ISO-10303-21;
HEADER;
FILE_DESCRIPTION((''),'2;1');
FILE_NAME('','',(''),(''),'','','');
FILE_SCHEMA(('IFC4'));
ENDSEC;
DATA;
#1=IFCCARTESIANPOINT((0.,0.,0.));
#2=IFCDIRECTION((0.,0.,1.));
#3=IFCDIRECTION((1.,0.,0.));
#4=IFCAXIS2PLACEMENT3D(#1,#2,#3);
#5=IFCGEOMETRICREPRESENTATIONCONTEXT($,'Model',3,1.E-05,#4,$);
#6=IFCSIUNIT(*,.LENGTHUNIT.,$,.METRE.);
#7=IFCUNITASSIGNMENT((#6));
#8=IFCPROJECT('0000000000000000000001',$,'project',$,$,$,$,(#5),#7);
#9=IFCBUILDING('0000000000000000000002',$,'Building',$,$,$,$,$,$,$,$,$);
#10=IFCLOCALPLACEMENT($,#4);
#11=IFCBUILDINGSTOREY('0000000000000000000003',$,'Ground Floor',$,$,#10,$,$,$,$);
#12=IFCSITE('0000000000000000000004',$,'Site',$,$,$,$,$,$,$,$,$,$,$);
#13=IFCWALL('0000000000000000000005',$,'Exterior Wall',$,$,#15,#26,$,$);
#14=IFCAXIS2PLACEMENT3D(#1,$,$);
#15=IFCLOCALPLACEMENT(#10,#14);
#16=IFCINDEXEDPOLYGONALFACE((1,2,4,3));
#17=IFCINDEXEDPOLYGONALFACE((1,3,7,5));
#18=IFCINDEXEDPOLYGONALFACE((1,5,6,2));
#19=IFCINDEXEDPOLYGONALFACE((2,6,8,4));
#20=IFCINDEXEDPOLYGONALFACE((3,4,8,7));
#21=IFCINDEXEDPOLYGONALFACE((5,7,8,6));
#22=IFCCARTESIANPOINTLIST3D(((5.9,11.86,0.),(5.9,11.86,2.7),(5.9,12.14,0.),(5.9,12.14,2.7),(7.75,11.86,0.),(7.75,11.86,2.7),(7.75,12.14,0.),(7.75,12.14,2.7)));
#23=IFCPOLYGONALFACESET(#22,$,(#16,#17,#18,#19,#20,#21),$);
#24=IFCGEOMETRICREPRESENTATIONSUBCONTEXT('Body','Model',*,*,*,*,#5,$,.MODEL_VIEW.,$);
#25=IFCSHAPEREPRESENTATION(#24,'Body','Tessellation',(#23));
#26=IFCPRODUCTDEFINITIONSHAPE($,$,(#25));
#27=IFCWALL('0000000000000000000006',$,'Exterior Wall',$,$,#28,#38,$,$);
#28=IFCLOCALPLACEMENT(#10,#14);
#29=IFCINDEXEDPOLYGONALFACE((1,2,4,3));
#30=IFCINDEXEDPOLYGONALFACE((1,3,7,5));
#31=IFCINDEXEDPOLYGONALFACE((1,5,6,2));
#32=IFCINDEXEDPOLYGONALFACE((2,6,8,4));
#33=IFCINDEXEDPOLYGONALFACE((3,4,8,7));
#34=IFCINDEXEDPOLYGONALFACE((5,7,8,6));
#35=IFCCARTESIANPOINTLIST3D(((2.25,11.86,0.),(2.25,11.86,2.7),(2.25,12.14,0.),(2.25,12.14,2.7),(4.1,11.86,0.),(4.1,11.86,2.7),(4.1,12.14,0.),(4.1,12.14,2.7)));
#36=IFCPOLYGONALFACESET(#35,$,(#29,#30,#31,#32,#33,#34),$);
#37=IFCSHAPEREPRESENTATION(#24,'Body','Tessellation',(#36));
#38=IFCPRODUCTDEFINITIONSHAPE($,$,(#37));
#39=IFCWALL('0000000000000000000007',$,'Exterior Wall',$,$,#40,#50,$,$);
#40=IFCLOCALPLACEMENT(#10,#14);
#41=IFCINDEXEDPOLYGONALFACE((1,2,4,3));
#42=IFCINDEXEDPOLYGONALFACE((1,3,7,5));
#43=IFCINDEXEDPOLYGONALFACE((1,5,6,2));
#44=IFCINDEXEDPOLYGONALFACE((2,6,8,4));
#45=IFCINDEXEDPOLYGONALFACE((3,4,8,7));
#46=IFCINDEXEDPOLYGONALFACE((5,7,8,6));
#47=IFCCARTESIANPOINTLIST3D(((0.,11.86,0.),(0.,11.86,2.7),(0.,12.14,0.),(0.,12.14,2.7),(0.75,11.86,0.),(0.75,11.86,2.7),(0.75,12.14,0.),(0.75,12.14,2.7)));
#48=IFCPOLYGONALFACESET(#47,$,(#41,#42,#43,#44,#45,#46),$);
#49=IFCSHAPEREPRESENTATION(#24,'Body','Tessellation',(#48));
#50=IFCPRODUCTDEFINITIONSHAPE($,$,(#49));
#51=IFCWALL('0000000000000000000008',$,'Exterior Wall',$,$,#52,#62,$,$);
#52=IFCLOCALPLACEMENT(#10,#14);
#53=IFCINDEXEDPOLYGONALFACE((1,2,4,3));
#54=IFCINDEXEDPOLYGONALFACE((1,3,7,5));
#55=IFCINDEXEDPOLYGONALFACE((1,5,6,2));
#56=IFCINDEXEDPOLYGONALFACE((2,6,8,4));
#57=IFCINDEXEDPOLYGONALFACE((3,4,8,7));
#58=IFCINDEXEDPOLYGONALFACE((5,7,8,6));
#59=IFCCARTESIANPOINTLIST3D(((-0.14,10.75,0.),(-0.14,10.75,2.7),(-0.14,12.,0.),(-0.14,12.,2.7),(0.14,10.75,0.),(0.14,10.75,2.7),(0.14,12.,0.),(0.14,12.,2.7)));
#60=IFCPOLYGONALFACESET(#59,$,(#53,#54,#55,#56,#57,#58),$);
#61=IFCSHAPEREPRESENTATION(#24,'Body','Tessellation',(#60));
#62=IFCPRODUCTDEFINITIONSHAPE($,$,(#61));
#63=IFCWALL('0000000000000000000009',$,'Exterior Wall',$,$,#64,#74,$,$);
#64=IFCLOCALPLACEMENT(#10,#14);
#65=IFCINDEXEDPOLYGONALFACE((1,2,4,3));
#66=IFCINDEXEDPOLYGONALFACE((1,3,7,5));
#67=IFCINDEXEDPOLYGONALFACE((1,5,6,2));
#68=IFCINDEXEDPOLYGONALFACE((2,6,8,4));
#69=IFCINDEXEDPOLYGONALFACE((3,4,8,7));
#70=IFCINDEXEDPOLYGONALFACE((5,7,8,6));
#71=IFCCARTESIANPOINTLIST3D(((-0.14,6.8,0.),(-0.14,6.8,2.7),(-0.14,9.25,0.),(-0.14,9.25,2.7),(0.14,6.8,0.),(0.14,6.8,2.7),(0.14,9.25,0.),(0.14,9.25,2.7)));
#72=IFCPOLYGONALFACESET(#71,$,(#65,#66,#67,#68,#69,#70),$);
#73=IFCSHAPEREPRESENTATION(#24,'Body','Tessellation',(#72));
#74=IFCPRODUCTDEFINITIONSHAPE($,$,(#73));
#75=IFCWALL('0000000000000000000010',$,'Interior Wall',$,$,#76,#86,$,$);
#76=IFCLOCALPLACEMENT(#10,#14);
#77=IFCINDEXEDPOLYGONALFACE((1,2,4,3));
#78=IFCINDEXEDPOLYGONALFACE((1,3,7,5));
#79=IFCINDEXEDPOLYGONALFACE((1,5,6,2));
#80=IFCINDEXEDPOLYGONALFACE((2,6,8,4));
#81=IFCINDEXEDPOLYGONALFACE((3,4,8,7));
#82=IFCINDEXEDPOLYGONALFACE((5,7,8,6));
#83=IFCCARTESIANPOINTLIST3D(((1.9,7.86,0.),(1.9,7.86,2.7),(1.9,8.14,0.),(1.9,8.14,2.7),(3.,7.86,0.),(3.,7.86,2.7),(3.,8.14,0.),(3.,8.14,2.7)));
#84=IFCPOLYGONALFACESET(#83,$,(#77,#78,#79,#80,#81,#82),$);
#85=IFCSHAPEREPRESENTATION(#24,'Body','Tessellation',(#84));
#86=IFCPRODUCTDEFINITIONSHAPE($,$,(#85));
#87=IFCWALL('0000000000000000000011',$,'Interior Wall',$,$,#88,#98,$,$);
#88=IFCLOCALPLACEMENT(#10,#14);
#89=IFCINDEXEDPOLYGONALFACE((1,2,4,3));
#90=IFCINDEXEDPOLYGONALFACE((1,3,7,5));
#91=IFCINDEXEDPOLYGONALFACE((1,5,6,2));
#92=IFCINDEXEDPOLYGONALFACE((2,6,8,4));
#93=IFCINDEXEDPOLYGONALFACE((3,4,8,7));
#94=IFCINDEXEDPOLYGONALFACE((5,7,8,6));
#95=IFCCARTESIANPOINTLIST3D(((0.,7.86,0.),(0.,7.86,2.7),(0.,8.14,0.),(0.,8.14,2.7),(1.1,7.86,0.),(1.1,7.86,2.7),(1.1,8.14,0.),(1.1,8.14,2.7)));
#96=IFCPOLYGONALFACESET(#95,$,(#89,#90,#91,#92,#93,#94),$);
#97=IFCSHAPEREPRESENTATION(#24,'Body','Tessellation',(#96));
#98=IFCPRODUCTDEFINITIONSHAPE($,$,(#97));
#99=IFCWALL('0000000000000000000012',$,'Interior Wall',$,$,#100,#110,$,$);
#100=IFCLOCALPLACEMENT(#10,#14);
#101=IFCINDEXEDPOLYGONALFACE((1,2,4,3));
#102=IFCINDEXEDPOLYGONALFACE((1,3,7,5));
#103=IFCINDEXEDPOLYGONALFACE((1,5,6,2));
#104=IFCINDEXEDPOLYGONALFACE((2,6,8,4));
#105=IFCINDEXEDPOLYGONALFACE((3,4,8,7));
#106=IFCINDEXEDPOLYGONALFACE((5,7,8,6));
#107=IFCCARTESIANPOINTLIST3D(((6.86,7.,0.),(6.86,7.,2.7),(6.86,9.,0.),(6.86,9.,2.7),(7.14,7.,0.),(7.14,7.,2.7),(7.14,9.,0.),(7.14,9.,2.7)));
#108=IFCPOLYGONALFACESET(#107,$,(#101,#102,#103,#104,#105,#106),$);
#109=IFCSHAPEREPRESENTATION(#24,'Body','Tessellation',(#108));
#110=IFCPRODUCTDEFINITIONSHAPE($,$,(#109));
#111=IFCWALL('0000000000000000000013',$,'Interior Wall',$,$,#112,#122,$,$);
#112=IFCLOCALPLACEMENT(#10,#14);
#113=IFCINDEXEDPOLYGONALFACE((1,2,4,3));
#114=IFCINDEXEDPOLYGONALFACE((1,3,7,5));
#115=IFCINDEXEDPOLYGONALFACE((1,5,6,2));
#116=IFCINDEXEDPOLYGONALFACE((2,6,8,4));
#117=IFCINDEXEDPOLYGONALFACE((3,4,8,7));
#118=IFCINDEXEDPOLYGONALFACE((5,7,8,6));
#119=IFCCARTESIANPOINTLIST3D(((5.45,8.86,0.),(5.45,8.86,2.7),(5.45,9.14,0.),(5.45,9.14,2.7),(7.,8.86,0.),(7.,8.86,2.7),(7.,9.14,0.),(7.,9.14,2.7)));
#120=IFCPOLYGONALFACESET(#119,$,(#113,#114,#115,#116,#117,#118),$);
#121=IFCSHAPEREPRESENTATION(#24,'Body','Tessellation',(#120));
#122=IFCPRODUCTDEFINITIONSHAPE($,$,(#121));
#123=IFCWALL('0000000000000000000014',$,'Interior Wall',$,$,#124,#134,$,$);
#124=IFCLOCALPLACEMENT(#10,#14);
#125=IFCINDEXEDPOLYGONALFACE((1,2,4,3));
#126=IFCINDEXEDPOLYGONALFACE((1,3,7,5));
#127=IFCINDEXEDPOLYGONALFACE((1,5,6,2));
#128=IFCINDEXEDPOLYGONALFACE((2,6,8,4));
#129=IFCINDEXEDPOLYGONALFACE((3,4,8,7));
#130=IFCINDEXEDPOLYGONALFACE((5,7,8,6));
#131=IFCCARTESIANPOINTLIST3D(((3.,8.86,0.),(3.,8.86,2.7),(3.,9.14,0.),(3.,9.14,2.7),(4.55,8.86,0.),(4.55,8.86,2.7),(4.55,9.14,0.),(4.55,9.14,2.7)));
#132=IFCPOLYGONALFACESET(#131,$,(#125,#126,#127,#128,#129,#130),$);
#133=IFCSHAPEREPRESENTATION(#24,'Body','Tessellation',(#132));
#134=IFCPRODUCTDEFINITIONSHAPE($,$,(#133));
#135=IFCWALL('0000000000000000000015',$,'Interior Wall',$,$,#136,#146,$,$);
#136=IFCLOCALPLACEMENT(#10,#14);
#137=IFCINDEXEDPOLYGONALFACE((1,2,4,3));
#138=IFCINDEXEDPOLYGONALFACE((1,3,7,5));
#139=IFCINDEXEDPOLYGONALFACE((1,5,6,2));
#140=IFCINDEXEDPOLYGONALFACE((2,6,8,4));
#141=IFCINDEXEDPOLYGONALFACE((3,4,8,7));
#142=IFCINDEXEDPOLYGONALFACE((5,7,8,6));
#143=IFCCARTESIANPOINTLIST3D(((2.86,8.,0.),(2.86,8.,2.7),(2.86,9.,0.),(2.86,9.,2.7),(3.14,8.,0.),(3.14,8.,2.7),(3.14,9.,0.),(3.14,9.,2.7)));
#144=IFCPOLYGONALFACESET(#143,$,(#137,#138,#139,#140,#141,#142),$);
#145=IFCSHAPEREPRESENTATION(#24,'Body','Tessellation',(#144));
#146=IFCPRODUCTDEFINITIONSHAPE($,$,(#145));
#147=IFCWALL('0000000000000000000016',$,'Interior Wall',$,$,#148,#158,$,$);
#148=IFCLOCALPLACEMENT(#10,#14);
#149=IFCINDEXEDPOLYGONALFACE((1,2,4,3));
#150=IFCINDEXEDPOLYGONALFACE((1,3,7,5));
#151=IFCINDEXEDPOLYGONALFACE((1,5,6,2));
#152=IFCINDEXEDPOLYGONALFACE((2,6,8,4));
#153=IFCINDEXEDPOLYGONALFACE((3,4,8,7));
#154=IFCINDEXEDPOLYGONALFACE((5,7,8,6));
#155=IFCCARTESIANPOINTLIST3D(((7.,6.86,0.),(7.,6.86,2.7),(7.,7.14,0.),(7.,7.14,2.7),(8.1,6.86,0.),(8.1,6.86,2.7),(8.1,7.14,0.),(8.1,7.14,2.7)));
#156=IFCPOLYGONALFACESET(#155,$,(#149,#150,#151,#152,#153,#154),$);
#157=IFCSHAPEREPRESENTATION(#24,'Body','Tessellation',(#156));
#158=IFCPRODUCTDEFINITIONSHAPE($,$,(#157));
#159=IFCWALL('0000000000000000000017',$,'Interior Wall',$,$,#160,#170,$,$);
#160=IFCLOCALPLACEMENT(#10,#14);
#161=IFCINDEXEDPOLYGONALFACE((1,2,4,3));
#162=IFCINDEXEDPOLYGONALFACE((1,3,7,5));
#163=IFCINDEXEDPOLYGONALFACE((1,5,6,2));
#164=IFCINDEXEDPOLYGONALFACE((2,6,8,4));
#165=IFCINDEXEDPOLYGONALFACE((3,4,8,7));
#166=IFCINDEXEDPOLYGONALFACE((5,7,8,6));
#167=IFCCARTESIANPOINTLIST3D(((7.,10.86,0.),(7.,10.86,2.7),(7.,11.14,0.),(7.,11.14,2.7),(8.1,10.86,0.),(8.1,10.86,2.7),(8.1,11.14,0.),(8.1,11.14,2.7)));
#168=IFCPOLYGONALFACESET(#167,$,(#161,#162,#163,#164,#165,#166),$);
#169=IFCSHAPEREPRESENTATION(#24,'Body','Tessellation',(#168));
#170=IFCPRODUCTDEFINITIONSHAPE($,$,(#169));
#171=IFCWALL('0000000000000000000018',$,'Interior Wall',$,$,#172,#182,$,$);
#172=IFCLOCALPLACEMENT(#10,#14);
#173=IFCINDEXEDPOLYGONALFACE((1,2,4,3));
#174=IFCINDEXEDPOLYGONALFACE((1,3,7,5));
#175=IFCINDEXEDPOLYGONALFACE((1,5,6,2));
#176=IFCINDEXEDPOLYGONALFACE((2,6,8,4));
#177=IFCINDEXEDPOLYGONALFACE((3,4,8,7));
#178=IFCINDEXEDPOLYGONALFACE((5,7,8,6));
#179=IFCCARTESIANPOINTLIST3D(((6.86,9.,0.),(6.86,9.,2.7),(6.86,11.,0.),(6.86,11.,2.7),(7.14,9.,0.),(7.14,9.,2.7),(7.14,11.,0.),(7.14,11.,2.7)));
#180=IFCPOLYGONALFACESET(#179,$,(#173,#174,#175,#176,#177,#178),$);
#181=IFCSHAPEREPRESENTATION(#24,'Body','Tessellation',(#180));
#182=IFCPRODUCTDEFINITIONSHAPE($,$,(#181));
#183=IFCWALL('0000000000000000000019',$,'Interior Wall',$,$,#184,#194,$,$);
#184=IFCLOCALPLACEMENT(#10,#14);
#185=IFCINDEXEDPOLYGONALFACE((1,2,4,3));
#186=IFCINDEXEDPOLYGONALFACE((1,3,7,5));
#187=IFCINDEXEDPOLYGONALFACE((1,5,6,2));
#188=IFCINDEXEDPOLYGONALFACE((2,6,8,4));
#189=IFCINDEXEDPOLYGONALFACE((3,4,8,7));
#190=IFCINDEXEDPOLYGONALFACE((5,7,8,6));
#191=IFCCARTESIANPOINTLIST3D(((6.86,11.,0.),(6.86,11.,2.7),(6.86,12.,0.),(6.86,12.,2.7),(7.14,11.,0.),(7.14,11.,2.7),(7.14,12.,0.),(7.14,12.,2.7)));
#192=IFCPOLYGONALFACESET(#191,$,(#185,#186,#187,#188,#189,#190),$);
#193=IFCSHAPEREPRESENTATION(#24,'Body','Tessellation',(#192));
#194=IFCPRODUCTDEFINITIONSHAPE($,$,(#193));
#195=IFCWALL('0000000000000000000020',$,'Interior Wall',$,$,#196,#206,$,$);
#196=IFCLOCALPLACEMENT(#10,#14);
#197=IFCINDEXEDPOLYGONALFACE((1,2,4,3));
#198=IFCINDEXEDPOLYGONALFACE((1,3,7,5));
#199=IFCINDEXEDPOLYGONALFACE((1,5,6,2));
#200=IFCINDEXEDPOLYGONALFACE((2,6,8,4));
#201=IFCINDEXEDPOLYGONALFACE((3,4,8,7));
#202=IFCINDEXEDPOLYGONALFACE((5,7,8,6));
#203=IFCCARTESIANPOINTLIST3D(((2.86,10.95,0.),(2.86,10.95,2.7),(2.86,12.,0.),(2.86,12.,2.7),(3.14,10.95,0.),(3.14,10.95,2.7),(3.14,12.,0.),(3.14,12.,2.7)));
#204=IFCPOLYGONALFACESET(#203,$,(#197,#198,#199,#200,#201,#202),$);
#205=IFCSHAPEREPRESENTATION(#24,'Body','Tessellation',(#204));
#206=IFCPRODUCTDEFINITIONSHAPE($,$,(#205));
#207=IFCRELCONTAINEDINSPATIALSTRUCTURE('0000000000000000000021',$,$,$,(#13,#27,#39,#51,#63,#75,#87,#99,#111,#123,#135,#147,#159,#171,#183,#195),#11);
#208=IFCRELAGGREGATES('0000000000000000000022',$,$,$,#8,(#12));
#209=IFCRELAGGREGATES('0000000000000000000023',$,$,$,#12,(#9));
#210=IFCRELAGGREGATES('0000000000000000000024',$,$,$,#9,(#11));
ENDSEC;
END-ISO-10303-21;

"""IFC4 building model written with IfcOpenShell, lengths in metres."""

from ifc_helpers import new_model, si_unit, frame, origin_with_axes, place, context, subcontext, project, spatial, indexed_curve, outline, extrude, element, save


model = new_model("IFC4")

# Units and contexts
model_context = context("Model", 3, precision=1e-05, world=origin_with_axes())
body_context = subcontext(model_context, "Body", "Model", "MODEL_VIEW")
ifc_project = project(units=[si_unit("LENGTHUNIT", "METRE")], contexts=[model_context])

# Site, building, storey
site = spatial("IfcSite", under=ifc_project, Name="Site")
building = spatial("IfcBuilding", under=site, Name="Building")
storey_placement = place(None, origin_with_axes())
storey = spatial("IfcBuildingStorey", under=building, at=storey_placement, Name="Ground Floor")

# Walls
for number, where, z_axis, x_axis, name in (
    (1, (7.75, 12.0, 0.0), (0.0, 0.0, 1.0), (-1.0, 0.0, 0.0), "Exterior Wall"),
    (2, (4.1, 12.0, 0.0), (0.0, 0.0, 1.0), (-1.0, 0.0, 0.0), "Exterior Wall"),
):
    element("IfcWall", number, at=place(storey_placement, frame(where, z_axis=z_axis, x_axis=x_axis)), inside=storey, Name=name, context=body_context, shape_type="SweptSolid", body=[
        extrude(outline(indexed_curve([(0.0, 0.0), (0.0, 0.28), (1.85, 0.28), (1.85, 0.0), (0.0, 0.0)], self_intersect=False)), frame((0.0, -0.14, 0.0), z_axis=(0.0, 0.0, 1.0), x_axis=(1.0, 0.0, 0.0)), (0.0, 0.0, 1.0), 2.7),
    ])
wall_1_placement = place(storey_placement, frame((0.75, 12.0, 0.0), z_axis=(0.0, 0.0, 1.0), x_axis=(-1.0, 0.0, 0.0)))
element("IfcWall", 3, at=wall_1_placement, inside=storey, Name="Exterior Wall", context=body_context, shape_type="SweptSolid", body=[
    extrude(outline(indexed_curve([(0.0, 0.0), (0.0, 0.28), (0.75, 0.28), (0.75, 0.0), (0.0, 0.0)], self_intersect=False)), frame((0.0, -0.14, 0.0), z_axis=(0.0, 0.0, 1.0), x_axis=(1.0, 0.0, 0.0)), (0.0, 0.0, 1.0), 2.7),
])
wall_2_placement = place(storey_placement, frame((0.0, 12.0, 0.0), z_axis=(0.0, 0.0, 1.0), x_axis=(0.0, -1.0, 0.0)))
element("IfcWall", 4, at=wall_2_placement, inside=storey, Name="Exterior Wall", context=body_context, shape_type="SweptSolid", body=[
    extrude(outline(indexed_curve([(0.0, 0.0), (0.0, 0.28), (1.25, 0.28), (1.25, 0.0), (0.0, 0.0)], self_intersect=False)), frame((0.0, -0.14, 0.0), z_axis=(0.0, 0.0, 1.0), x_axis=(1.0, 0.0, 0.0)), (0.0, 0.0, 1.0), 2.7),
])
wall_3_placement = place(storey_placement, frame((0.0, 9.25, 0.0), z_axis=(0.0, 0.0, 1.0), x_axis=(0.0, -1.0, 0.0)))
element("IfcWall", 5, at=wall_3_placement, inside=storey, Name="Exterior Wall", context=body_context, shape_type="SweptSolid", body=[
    extrude(outline(indexed_curve([(0.0, 0.0), (0.0, 0.28), (2.45, 0.28), (2.45, 0.0), (0.0, 0.0)], self_intersect=False)), frame((0.0, -0.14, 0.0), z_axis=(0.0, 0.0, 1.0), x_axis=(1.0, 0.0, 0.0)), (0.0, 0.0, 1.0), 2.7),
])
for number, where, z_axis, x_axis, name in (
    (6, (3.0, 8.0, 0.0), (0.0, 0.0, 1.0), (-1.0, 0.0, 0.0), "Interior Wall"),
    (7, (1.1, 8.0, 0.0), (0.0, 0.0, 1.0), (-1.0, 0.0, 0.0), "Interior Wall"),
):
    element("IfcWall", number, at=place(storey_placement, frame(where, z_axis=z_axis, x_axis=x_axis)), inside=storey, Name=name, context=body_context, shape_type="SweptSolid", body=[
        extrude(outline(indexed_curve([(0.0, 0.0), (0.0, 0.28), (1.1, 0.28), (1.1, 0.0), (0.0, 0.0)], self_intersect=False)), frame((0.0, -0.14, 0.0), z_axis=(0.0, 0.0, 1.0), x_axis=(1.0, 0.0, 0.0)), (0.0, 0.0, 1.0), 2.7),
    ])
wall_4_placement = place(storey_placement, frame((7.0, 7.0, 0.0), z_axis=(0.0, 0.0, 1.0), x_axis=(0.0, 1.0, 0.0)))
element("IfcWall", 8, at=wall_4_placement, inside=storey, Name="Interior Wall", context=body_context, shape_type="SweptSolid", body=[
    extrude(outline(indexed_curve([(0.0, 0.0), (0.0, 0.28), (2.0, 0.28), (2.0, 0.0), (0.0, 0.0)], self_intersect=False)), frame((0.0, -0.14, 0.0), z_axis=(0.0, 0.0, 1.0), x_axis=(1.0, 0.0, 0.0)), (0.0, 0.0, 1.0), 2.7),
])
for number, where, z_axis, x_axis, name in (
    (9, (7.0, 9.0, 0.0), (0.0, 0.0, 1.0), (-1.0, 0.0, 0.0), "Interior Wall"),
    (10, (4.55, 9.0, 0.0), (0.0, 0.0, 1.0), (-1.0, 0.0, 0.0), "Interior Wall"),
):
    element("IfcWall", number, at=place(storey_placement, frame(where, z_axis=z_axis, x_axis=x_axis)), inside=storey, Name=name, context=body_context, shape_type="SweptSolid", body=[
        extrude(outline(indexed_curve([(0.0, 0.0), (0.0, 0.28), (1.55, 0.28), (1.55, 0.0), (0.0, 0.0)], self_intersect=False)), frame((0.0, -0.14, 0.0), z_axis=(0.0, 0.0, 1.0), x_axis=(1.0, 0.0, 0.0)), (0.0, 0.0, 1.0), 2.7),
    ])
wall_5_placement = place(storey_placement, frame((3.0, 9.0, 0.0), z_axis=(0.0, 0.0, 1.0), x_axis=(0.0, -1.0, 0.0)))
element("IfcWall", 11, at=wall_5_placement, inside=storey, Name="Interior Wall", context=body_context, shape_type="SweptSolid", body=[
    extrude(outline(indexed_curve([(0.0, 0.0), (0.0, 0.28), (1.0, 0.28), (1.0, 0.0), (0.0, 0.0)], self_intersect=False)), frame((0.0, -0.14, 0.0), z_axis=(0.0, 0.0, 1.0), x_axis=(1.0, 0.0, 0.0)), (0.0, 0.0, 1.0), 2.7),
])
for number, where, z_axis, x_axis, name in (
    (12, (8.1, 7.0, 0.0), (0.0, 0.0, 1.0), (-1.0, 0.0, 0.0), "Interior Wall"),
    (13, (8.1, 11.0, 0.0), (0.0, 0.0, 1.0), (-1.0, 0.0, 0.0), "Interior Wall"),
):
    element("IfcWall", number, at=place(storey_placement, frame(where, z_axis=z_axis, x_axis=x_axis)), inside=storey, Name=name, context=body_context, shape_type="SweptSolid", body=[
        extrude(outline(indexed_curve([(0.0, 0.0), (0.0, 0.28), (1.1, 0.28), (1.1, 0.0), (0.0, 0.0)], self_intersect=False)), frame((0.0, -0.14, 0.0), z_axis=(0.0, 0.0, 1.0), x_axis=(1.0, 0.0, 0.0)), (0.0, 0.0, 1.0), 2.7),
    ])
wall_6_placement = place(storey_placement, frame((7.0, 11.0, 0.0), z_axis=(0.0, 0.0, 1.0), x_axis=(0.0, -1.0, 0.0)))
element("IfcWall", 14, at=wall_6_placement, inside=storey, Name="Interior Wall", context=body_context, shape_type="SweptSolid", body=[
    extrude(outline(indexed_curve([(0.0, 0.0), (0.0, 0.28), (2.0, 0.28), (2.0, 0.0), (0.0, 0.0)], self_intersect=False)), frame((0.0, -0.14, 0.0), z_axis=(0.0, 0.0, 1.0), x_axis=(1.0, 0.0, 0.0)), (0.0, 0.0, 1.0), 2.7),
])
wall_7_placement = place(storey_placement, frame((7.0, 11.0, 0.0), z_axis=(0.0, 0.0, 1.0), x_axis=(0.0, 1.0, 0.0)))
element("IfcWall", 15, at=wall_7_placement, inside=storey, Name="Interior Wall", context=body_context, shape_type="SweptSolid", body=[
    extrude(outline(indexed_curve([(0.0, 0.0), (0.0, 0.28), (1.0, 0.28), (1.0, 0.0), (0.0, 0.0)], self_intersect=False)), frame((0.0, -0.14, 0.0), z_axis=(0.0, 0.0, 1.0), x_axis=(1.0, 0.0, 0.0)), (0.0, 0.0, 1.0), 2.7),
])
for number, where, z_axis, x_axis, name in (
    (16, (3.0, 12.0, 0.0), (0.0, 0.0, 1.0), (0.0, -1.0, 0.0), "Interior Wall"),
):
    element("IfcWall", number, at=place(storey_placement, frame(where, z_axis=z_axis, x_axis=x_axis)), inside=storey, Name=name, context=body_context, shape_type="SweptSolid", body=[
        extrude(outline(indexed_curve([(0.0, 0.0), (0.0, 0.28), (1.05, 0.28), (1.05, 0.0), (0.0, 0.0)], self_intersect=False)), frame((0.0, -0.14, 0.0), z_axis=(0.0, 0.0, 1.0), x_axis=(1.0, 0.0, 0.0)), (0.0, 0.0, 1.0), 2.7),
    ])

save(model, "model.ifc")
